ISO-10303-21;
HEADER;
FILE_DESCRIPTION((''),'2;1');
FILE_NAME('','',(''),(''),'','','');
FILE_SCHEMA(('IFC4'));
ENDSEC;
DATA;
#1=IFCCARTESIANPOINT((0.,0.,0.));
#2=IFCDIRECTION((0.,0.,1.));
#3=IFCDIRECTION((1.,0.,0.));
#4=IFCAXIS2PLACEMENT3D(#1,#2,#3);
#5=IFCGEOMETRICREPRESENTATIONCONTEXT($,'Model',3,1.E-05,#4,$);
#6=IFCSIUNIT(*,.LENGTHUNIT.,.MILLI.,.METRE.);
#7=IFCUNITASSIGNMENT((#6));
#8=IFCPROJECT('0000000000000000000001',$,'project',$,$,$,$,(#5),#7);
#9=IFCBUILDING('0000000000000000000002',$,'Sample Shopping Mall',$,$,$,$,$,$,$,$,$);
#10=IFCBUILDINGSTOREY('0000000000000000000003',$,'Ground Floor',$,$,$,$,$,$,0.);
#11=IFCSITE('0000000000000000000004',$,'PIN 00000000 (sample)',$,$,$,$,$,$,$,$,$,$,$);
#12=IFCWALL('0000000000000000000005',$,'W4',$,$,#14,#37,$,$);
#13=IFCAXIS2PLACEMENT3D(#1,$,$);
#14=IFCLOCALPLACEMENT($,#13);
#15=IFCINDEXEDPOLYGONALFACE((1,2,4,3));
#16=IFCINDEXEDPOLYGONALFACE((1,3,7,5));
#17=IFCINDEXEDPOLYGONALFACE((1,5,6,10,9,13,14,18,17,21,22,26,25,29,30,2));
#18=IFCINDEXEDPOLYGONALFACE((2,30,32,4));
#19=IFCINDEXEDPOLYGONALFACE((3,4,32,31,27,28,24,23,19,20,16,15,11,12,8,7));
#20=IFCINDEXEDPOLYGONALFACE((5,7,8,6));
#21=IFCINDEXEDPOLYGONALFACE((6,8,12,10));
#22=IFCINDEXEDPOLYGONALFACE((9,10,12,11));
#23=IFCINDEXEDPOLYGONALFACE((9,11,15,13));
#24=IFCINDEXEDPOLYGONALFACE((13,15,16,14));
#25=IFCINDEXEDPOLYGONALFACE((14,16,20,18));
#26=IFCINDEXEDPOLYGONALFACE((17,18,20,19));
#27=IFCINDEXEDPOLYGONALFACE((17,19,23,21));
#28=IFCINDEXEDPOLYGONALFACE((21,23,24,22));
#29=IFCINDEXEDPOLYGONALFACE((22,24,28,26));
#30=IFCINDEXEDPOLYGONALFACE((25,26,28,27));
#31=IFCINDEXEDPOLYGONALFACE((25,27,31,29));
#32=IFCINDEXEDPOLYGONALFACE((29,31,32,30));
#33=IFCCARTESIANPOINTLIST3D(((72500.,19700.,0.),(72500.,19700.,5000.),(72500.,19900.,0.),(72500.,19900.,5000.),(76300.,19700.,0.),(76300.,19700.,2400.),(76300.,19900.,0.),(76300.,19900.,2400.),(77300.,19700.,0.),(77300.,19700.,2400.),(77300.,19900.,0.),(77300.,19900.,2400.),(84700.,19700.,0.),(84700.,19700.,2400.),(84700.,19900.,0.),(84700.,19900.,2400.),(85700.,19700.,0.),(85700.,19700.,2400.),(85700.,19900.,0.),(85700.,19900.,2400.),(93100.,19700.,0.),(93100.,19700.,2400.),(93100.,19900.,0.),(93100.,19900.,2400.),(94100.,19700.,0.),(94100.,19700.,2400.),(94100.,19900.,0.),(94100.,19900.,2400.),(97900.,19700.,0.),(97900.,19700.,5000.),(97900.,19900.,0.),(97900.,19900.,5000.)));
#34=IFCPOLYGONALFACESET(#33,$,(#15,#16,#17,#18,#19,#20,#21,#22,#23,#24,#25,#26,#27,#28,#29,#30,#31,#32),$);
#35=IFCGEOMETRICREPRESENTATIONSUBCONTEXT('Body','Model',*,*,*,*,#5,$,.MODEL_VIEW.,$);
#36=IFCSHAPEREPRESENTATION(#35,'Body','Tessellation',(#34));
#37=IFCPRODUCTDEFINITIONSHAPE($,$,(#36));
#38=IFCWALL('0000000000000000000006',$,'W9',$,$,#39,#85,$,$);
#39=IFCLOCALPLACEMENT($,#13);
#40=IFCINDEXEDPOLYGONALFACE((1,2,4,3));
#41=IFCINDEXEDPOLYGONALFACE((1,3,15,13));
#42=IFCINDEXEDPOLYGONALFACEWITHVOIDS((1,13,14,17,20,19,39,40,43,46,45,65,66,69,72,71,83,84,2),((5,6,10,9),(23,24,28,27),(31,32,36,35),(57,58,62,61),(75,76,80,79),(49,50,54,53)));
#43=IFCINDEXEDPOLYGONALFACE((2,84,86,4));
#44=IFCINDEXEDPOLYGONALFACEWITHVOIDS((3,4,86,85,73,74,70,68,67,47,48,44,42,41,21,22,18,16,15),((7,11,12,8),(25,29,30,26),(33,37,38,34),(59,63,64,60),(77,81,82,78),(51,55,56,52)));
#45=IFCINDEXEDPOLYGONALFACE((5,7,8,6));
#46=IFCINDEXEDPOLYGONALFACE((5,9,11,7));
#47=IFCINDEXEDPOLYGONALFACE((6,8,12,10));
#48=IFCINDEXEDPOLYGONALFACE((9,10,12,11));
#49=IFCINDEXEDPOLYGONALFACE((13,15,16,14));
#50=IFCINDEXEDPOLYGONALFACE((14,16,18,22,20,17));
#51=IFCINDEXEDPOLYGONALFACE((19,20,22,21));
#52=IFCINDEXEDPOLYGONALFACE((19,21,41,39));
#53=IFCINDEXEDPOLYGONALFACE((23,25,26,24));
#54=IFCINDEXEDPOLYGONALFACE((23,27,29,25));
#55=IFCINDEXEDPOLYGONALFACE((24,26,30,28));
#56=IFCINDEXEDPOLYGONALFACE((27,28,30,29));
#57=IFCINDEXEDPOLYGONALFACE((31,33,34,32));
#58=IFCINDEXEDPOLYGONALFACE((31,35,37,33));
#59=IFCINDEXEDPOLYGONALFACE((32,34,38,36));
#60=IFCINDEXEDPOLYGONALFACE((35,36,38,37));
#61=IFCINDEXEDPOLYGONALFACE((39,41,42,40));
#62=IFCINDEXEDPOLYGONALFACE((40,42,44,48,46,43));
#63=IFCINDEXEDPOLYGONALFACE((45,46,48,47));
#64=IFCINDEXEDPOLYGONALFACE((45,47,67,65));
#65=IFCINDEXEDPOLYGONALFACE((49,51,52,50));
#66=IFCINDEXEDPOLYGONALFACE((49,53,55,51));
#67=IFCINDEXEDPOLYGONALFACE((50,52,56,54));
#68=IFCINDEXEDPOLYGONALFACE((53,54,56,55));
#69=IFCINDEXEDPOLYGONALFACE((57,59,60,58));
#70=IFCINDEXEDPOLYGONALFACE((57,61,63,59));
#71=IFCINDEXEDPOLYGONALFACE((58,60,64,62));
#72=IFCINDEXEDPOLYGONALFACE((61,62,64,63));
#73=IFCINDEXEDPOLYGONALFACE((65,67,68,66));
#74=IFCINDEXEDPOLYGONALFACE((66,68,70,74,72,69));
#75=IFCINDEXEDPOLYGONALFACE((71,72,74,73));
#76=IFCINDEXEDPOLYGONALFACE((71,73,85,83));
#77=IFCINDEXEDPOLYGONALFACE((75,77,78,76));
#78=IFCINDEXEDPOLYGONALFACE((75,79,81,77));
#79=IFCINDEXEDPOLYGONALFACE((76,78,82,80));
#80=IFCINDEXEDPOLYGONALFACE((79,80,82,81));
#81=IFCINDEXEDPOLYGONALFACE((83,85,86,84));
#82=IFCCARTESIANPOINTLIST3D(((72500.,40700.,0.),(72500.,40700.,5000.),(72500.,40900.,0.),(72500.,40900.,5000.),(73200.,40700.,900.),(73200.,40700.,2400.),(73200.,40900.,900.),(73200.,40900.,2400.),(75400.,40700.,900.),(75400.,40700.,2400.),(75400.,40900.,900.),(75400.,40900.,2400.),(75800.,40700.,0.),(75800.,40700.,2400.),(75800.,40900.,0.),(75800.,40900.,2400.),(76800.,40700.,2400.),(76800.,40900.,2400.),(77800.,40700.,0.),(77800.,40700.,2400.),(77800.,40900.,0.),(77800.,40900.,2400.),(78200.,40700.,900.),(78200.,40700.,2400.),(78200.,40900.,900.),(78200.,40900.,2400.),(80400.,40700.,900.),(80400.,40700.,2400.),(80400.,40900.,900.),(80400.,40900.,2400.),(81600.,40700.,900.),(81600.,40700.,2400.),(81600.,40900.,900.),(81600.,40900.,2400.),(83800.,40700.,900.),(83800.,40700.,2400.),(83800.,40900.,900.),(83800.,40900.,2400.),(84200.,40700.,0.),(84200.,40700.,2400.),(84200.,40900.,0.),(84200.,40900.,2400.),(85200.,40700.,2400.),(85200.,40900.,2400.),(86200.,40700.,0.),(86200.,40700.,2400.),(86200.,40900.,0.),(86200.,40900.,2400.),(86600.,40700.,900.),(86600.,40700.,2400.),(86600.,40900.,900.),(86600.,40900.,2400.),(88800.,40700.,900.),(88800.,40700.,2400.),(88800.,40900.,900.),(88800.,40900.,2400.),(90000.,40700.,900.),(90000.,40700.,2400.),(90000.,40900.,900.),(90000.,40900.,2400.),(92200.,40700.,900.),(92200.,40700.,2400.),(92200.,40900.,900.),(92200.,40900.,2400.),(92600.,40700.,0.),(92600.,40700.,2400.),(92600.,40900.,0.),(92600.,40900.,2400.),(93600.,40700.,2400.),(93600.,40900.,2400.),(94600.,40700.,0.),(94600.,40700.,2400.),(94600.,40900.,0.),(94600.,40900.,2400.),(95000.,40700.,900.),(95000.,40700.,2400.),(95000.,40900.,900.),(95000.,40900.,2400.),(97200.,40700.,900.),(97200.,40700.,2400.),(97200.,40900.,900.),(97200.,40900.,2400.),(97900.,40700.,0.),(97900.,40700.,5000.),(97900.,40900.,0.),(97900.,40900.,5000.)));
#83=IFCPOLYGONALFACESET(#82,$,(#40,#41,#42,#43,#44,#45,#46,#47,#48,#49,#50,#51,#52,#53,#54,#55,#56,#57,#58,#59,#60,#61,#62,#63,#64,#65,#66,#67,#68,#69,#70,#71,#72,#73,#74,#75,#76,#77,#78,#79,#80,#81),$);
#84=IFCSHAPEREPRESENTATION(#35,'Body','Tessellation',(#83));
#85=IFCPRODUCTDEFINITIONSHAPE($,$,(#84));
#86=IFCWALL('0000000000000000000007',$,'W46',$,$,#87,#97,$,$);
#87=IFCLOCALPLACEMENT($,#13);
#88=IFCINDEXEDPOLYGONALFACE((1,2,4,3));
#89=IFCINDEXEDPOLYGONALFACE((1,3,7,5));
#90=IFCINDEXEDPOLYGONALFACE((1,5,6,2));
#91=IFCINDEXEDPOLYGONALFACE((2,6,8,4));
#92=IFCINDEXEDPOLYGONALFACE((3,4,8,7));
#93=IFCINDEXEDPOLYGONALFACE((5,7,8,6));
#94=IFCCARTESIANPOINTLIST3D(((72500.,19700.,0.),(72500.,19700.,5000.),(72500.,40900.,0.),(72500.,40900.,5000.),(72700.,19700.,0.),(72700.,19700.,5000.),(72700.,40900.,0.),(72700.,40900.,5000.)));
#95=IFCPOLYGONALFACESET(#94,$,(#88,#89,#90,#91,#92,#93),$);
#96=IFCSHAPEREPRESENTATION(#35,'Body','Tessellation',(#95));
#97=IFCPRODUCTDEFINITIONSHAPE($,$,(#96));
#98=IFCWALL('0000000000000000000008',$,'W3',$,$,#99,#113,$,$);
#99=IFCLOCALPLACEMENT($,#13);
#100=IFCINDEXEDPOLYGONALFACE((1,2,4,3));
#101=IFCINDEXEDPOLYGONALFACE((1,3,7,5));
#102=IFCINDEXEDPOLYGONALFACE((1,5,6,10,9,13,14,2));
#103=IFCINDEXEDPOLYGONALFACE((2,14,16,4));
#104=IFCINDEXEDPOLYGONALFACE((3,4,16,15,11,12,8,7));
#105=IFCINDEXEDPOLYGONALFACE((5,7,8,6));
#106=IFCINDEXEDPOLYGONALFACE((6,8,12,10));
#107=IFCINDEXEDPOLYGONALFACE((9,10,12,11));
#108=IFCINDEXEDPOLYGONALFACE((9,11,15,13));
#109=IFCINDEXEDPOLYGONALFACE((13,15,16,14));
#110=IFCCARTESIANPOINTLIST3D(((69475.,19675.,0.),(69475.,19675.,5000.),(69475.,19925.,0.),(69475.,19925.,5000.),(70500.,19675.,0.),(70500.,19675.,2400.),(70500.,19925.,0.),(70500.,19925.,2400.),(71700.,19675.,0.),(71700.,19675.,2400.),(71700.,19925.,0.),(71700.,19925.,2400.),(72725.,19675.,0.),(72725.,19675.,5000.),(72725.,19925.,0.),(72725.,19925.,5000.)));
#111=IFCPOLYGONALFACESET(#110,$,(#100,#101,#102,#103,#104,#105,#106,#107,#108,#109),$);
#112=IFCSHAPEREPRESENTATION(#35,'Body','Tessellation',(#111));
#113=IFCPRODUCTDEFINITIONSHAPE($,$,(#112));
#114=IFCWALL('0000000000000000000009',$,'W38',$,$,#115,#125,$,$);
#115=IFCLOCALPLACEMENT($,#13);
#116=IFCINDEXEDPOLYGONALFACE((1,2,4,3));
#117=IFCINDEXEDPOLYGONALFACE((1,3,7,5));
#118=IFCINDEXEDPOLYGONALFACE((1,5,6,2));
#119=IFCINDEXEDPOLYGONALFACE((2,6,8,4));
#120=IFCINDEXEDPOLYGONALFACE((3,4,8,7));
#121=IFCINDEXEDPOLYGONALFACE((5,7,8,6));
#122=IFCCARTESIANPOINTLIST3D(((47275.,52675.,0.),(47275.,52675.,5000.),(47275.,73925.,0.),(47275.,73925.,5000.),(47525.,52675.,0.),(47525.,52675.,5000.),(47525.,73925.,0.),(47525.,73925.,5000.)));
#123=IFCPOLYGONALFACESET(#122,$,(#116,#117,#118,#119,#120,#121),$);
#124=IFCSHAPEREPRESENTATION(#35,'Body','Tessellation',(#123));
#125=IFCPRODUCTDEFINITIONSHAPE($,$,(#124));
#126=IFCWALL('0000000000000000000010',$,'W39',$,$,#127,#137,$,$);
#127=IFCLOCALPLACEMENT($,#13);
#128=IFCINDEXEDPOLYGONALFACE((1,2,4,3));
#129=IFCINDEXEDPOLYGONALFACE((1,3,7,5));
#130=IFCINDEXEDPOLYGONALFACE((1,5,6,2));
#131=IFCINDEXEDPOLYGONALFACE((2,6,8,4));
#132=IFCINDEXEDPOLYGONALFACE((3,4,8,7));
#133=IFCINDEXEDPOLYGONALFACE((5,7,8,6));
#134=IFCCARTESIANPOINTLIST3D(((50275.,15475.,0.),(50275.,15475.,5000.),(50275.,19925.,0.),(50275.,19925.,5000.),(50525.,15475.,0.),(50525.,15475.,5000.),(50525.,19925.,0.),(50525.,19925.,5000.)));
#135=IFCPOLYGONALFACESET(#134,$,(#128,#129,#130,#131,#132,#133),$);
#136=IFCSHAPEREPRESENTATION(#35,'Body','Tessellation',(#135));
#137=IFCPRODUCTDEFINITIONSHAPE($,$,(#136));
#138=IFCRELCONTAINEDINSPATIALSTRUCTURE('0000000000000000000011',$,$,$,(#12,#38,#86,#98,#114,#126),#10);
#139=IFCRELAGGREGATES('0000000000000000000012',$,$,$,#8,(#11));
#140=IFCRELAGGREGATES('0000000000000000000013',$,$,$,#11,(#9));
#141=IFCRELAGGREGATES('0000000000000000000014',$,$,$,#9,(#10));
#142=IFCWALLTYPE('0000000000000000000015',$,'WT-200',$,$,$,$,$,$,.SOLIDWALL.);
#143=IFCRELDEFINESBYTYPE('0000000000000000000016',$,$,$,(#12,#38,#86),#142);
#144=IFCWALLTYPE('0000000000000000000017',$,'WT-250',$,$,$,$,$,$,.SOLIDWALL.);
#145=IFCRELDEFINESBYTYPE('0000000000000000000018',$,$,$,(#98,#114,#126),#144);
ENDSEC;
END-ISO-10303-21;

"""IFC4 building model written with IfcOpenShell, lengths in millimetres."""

from ifc_helpers import new_model, si_unit, frame, origin_with_axes, place, context, subcontext, project, spatial, indexed_curve, outline, extrude, type_object, element, save


model = new_model("IFC4")

# Units and contexts
model_context = context("Model", 3, precision=1e-05, world=origin_with_axes())
body_context = subcontext(model_context, "Body", "Model", "MODEL_VIEW")
ifc_project = project(units=[si_unit("LENGTHUNIT", "METRE", prefix="MILLI")], contexts=[model_context])

# Site, building, storey
site = spatial("IfcSite", under=ifc_project, Name="PIN 00000000 (sample)")
building = spatial("IfcBuilding", under=site, Name="Sample Shopping Mall")
storey = spatial("IfcBuildingStorey", under=building, Name="Ground Floor", Elevation=0.0)

# Walls, openings
wall_type_1 = type_object("IfcWallType", Name="WT-200", PredefinedType="SOLIDWALL")
wall_1_placement = place(None, frame((72500.0, 19700.0, 0.0), z_axis=(0.0, 0.0, 1.0), x_axis=(1.0, 0.0, 0.0)))
wall_1 = element("IfcWall", 1, at=wall_1_placement, inside=storey, type_object=wall_type_1, Name="W4", context=body_context, shape_type="SweptSolid", body=[
    extrude(outline(indexed_curve([(0.0, 0.0), (0.0, 200.0), (25400.0, 200.0), (25400.0, 0.0), (0.0, 0.0)], self_intersect=False)), origin_with_axes(), (0.0, 0.0, 1.0), 5000.0),
])
opening_1_placement = place(wall_1_placement, frame((3800.0, -100.0, 0.0), z_axis=(0.0, 0.0, 1.0), x_axis=(1.0, 0.0, 0.0)))
element("IfcOpeningElement", 2, at=opening_1_placement, cuts=wall_1, context=body_context, shape_type="SweptSolid", body=[
    extrude(outline(indexed_curve([(0.0, 0.0), (0.0, 400.0), (1000.0, 400.0), (1000.0, 0.0), (0.0, 0.0)], self_intersect=False)), origin_with_axes(), (0.0, 0.0, 1.0), 2400.0),
])
opening_2_placement = place(wall_1_placement, frame((12200.0, -100.0, 0.0), z_axis=(0.0, 0.0, 1.0), x_axis=(1.0, 0.0, 0.0)))
element("IfcOpeningElement", 3, at=opening_2_placement, cuts=wall_1, context=body_context, shape_type="SweptSolid", body=[
    extrude(outline(indexed_curve([(0.0, 0.0), (0.0, 400.0), (1000.0, 400.0), (1000.0, 0.0), (0.0, 0.0)], self_intersect=False)), origin_with_axes(), (0.0, 0.0, 1.0), 2400.0),
])
opening_3_placement = place(wall_1_placement, frame((20600.0, -100.0, 0.0), z_axis=(0.0, 0.0, 1.0), x_axis=(1.0, 0.0, 0.0)))
element("IfcOpeningElement", 4, at=opening_3_placement, cuts=wall_1, context=body_context, shape_type="SweptSolid", body=[
    extrude(outline(indexed_curve([(0.0, 0.0), (0.0, 400.0), (1000.0, 400.0), (1000.0, 0.0), (0.0, 0.0)], self_intersect=False)), origin_with_axes(), (0.0, 0.0, 1.0), 2400.0),
])
wall_2_placement = place(None, frame((72500.0, 40700.0, 0.0), z_axis=(0.0, 0.0, 1.0), x_axis=(1.0, 0.0, 0.0)))
wall_2 = element("IfcWall", 5, at=wall_2_placement, inside=storey, type_object=wall_type_1, Name="W9", context=body_context, shape_type="SweptSolid", body=[
    extrude(outline(indexed_curve([(0.0, 0.0), (0.0, 200.0), (25400.0, 200.0), (25400.0, 0.0), (0.0, 0.0)], self_intersect=False)), origin_with_axes(), (0.0, 0.0, 1.0), 5000.0),
])
opening_4_placement = place(wall_2_placement, frame((3300.0, -100.0, 0.0), z_axis=(0.0, 0.0, 1.0), x_axis=(1.0, 0.0, 0.0)))
element("IfcOpeningElement", 6, at=opening_4_placement, cuts=wall_2, context=body_context, shape_type="SweptSolid", body=[
    extrude(outline(indexed_curve([(0.0, 0.0), (0.0, 400.0), (1000.0, 400.0), (1000.0, 0.0), (0.0, 0.0)], self_intersect=False)), origin_with_axes(), (0.0, 0.0, 1.0), 2400.0),
])
opening_5_placement = place(wall_2_placement, frame((4300.0, -100.0, 0.0), z_axis=(0.0, 0.0, 1.0), x_axis=(1.0, 0.0, 0.0)))
element("IfcOpeningElement", 7, at=opening_5_placement, cuts=wall_2, context=body_context, shape_type="SweptSolid", body=[
    extrude(outline(indexed_curve([(0.0, 0.0), (0.0, 400.0), (1000.0, 400.0), (1000.0, 0.0), (0.0, 0.0)], self_intersect=False)), origin_with_axes(), (0.0, 0.0, 1.0), 2400.0),
])
opening_6_placement = place(wall_2_placement, frame((11700.0, -100.0, 0.0), z_axis=(0.0, 0.0, 1.0), x_axis=(1.0, 0.0, 0.0)))
element("IfcOpeningElement", 8, at=opening_6_placement, cuts=wall_2, context=body_context, shape_type="SweptSolid", body=[
    extrude(outline(indexed_curve([(0.0, 0.0), (0.0, 400.0), (1000.0, 400.0), (1000.0, 0.0), (0.0, 0.0)], self_intersect=False)), origin_with_axes(), (0.0, 0.0, 1.0), 2400.0),
])
opening_7_placement = place(wall_2_placement, frame((12700.0, -100.0, 0.0), z_axis=(0.0, 0.0, 1.0), x_axis=(1.0, 0.0, 0.0)))
element("IfcOpeningElement", 9, at=opening_7_placement, cuts=wall_2, context=body_context, shape_type="SweptSolid", body=[
    extrude(outline(indexed_curve([(0.0, 0.0), (0.0, 400.0), (1000.0, 400.0), (1000.0, 0.0), (0.0, 0.0)], self_intersect=False)), origin_with_axes(), (0.0, 0.0, 1.0), 2400.0),
])
opening_8_placement = place(wall_2_placement, frame((20100.0, -100.0, 0.0), z_axis=(0.0, 0.0, 1.0), x_axis=(1.0, 0.0, 0.0)))
element("IfcOpeningElement", 10, at=opening_8_placement, cuts=wall_2, context=body_context, shape_type="SweptSolid", body=[
    extrude(outline(indexed_curve([(0.0, 0.0), (0.0, 400.0), (1000.0, 400.0), (1000.0, 0.0), (0.0, 0.0)], self_intersect=False)), origin_with_axes(), (0.0, 0.0, 1.0), 2400.0),
])
opening_9_placement = place(wall_2_placement, frame((21100.0, -100.0, 0.0), z_axis=(0.0, 0.0, 1.0), x_axis=(1.0, 0.0, 0.0)))
element("IfcOpeningElement", 11, at=opening_9_placement, cuts=wall_2, context=body_context, shape_type="SweptSolid", body=[
    extrude(outline(indexed_curve([(0.0, 0.0), (0.0, 400.0), (1000.0, 400.0), (1000.0, 0.0), (0.0, 0.0)], self_intersect=False)), origin_with_axes(), (0.0, 0.0, 1.0), 2400.0),
])
opening_10_placement = place(wall_2_placement, frame((700.0, -100.0, 900.0), z_axis=(0.0, 0.0, 1.0), x_axis=(1.0, 0.0, 0.0)))
element("IfcOpeningElement", 12, at=opening_10_placement, cuts=wall_2, context=body_context, shape_type="SweptSolid", body=[
    extrude(outline(indexed_curve([(0.0, 0.0), (0.0, 400.0), (2200.0, 400.0), (2200.0, 0.0), (0.0, 0.0)], self_intersect=False)), origin_with_axes(), (0.0, 0.0, 1.0), 1500.0),
])
opening_11_placement = place(wall_2_placement, frame((5700.0, -100.0, 900.0), z_axis=(0.0, 0.0, 1.0), x_axis=(1.0, 0.0, 0.0)))
element("IfcOpeningElement", 13, at=opening_11_placement, cuts=wall_2, context=body_context, shape_type="SweptSolid", body=[
    extrude(outline(indexed_curve([(0.0, 0.0), (0.0, 400.0), (2200.0, 400.0), (2200.0, 0.0), (0.0, 0.0)], self_intersect=False)), origin_with_axes(), (0.0, 0.0, 1.0), 1500.0),
])
opening_12_placement = place(wall_2_placement, frame((9100.0, -100.0, 900.0), z_axis=(0.0, 0.0, 1.0), x_axis=(1.0, 0.0, 0.0)))
element("IfcOpeningElement", 14, at=opening_12_placement, cuts=wall_2, context=body_context, shape_type="SweptSolid", body=[
    extrude(outline(indexed_curve([(0.0, 0.0), (0.0, 400.0), (2200.0, 400.0), (2200.0, 0.0), (0.0, 0.0)], self_intersect=False)), origin_with_axes(), (0.0, 0.0, 1.0), 1500.0),
])
opening_13_placement = place(wall_2_placement, frame((14100.0, -100.0, 900.0), z_axis=(0.0, 0.0, 1.0), x_axis=(1.0, 0.0, 0.0)))
element("IfcOpeningElement", 15, at=opening_13_placement, cuts=wall_2, context=body_context, shape_type="SweptSolid", body=[
    extrude(outline(indexed_curve([(0.0, 0.0), (0.0, 400.0), (2200.0, 400.0), (2200.0, 0.0), (0.0, 0.0)], self_intersect=False)), origin_with_axes(), (0.0, 0.0, 1.0), 1500.0),
])
opening_14_placement = place(wall_2_placement, frame((17500.0, -100.0, 900.0), z_axis=(0.0, 0.0, 1.0), x_axis=(1.0, 0.0, 0.0)))
element("IfcOpeningElement", 16, at=opening_14_placement, cuts=wall_2, context=body_context, shape_type="SweptSolid", body=[
    extrude(outline(indexed_curve([(0.0, 0.0), (0.0, 400.0), (2200.0, 400.0), (2200.0, 0.0), (0.0, 0.0)], self_intersect=False)), origin_with_axes(), (0.0, 0.0, 1.0), 1500.0),
])
opening_15_placement = place(wall_2_placement, frame((22500.0, -100.0, 900.0), z_axis=(0.0, 0.0, 1.0), x_axis=(1.0, 0.0, 0.0)))
element("IfcOpeningElement", 17, at=opening_15_placement, cuts=wall_2, context=body_context, shape_type="SweptSolid", body=[
    extrude(outline(indexed_curve([(0.0, 0.0), (0.0, 400.0), (2200.0, 400.0), (2200.0, 0.0), (0.0, 0.0)], self_intersect=False)), origin_with_axes(), (0.0, 0.0, 1.0), 1500.0),
])

# Wall
wall_3_placement = place(None, frame((72700.0, 19700.0, 0.0), z_axis=(0.0, 0.0, 1.0), x_axis=(0.0, 1.0, 0.0)))
element("IfcWall", 18, at=wall_3_placement, inside=storey, type_object=wall_type_1, Name="W46", context=body_context, shape_type="SweptSolid", body=[
    extrude(outline(indexed_curve([(0.0, 0.0), (0.0, 200.0), (21200.0, 200.0), (21200.0, 0.0), (0.0, 0.0)], self_intersect=False)), origin_with_axes(), (0.0, 0.0, 1.0), 5000.0),
])

# Wall, opening
wall_type_2 = type_object("IfcWallType", Name="WT-250", PredefinedType="SOLIDWALL")
wall_4_placement = place(None, frame((69475.0, 19675.0, 0.0), z_axis=(0.0, 0.0, 1.0), x_axis=(1.0, 0.0, 0.0)))
wall_4 = element("IfcWall", 19, at=wall_4_placement, inside=storey, type_object=wall_type_2, Name="W3", context=body_context, shape_type="SweptSolid", body=[
    extrude(outline(indexed_curve([(0.0, 0.0), (0.0, 250.0), (3250.0, 250.0), (3250.0, 0.0), (0.0, 0.0)], self_intersect=False)), origin_with_axes(), (0.0, 0.0, 1.0), 5000.0),
])
opening_16_placement = place(wall_4_placement, frame((1025.0, -100.0, 0.0), z_axis=(0.0, 0.0, 1.0), x_axis=(1.0, 0.0, 0.0)))
element("IfcOpeningElement", 20, at=opening_16_placement, cuts=wall_4, context=body_context, shape_type="SweptSolid", body=[
    extrude(outline(indexed_curve([(0.0, 0.0), (0.0, 450.0), (1200.0, 450.0), (1200.0, 0.0), (0.0, 0.0)], self_intersect=False)), origin_with_axes(), (0.0, 0.0, 1.0), 2400.0),
])

# Walls
wall_5_placement = place(None, frame((47525.0, 52675.0, 0.0), z_axis=(0.0, 0.0, 1.0), x_axis=(0.0, 1.0, 0.0)))
element("IfcWall", 21, at=wall_5_placement, inside=storey, type_object=wall_type_2, Name="W38", context=body_context, shape_type="SweptSolid", body=[
    extrude(outline(indexed_curve([(0.0, 0.0), (0.0, 250.0), (21250.0, 250.0), (21250.0, 0.0), (0.0, 0.0)], self_intersect=False)), origin_with_axes(), (0.0, 0.0, 1.0), 5000.0),
])
for number, where, z_axis, x_axis, name in (
    (22, (50525.0, 15475.0, 0.0), (0.0, 0.0, 1.0), (0.0, 1.0, 0.0), "W39"),
):
    element("IfcWall", number, at=place(None, frame(where, z_axis=z_axis, x_axis=x_axis)), inside=storey, type_object=wall_type_2, Name=name, context=body_context, shape_type="SweptSolid", body=[
        extrude(outline(indexed_curve([(0.0, 0.0), (0.0, 250.0), (4450.0, 250.0), (4450.0, 0.0), (0.0, 0.0)], self_intersect=False)), origin_with_axes(), (0.0, 0.0, 1.0), 5000.0),
    ])

save(model, "model.ifc")
